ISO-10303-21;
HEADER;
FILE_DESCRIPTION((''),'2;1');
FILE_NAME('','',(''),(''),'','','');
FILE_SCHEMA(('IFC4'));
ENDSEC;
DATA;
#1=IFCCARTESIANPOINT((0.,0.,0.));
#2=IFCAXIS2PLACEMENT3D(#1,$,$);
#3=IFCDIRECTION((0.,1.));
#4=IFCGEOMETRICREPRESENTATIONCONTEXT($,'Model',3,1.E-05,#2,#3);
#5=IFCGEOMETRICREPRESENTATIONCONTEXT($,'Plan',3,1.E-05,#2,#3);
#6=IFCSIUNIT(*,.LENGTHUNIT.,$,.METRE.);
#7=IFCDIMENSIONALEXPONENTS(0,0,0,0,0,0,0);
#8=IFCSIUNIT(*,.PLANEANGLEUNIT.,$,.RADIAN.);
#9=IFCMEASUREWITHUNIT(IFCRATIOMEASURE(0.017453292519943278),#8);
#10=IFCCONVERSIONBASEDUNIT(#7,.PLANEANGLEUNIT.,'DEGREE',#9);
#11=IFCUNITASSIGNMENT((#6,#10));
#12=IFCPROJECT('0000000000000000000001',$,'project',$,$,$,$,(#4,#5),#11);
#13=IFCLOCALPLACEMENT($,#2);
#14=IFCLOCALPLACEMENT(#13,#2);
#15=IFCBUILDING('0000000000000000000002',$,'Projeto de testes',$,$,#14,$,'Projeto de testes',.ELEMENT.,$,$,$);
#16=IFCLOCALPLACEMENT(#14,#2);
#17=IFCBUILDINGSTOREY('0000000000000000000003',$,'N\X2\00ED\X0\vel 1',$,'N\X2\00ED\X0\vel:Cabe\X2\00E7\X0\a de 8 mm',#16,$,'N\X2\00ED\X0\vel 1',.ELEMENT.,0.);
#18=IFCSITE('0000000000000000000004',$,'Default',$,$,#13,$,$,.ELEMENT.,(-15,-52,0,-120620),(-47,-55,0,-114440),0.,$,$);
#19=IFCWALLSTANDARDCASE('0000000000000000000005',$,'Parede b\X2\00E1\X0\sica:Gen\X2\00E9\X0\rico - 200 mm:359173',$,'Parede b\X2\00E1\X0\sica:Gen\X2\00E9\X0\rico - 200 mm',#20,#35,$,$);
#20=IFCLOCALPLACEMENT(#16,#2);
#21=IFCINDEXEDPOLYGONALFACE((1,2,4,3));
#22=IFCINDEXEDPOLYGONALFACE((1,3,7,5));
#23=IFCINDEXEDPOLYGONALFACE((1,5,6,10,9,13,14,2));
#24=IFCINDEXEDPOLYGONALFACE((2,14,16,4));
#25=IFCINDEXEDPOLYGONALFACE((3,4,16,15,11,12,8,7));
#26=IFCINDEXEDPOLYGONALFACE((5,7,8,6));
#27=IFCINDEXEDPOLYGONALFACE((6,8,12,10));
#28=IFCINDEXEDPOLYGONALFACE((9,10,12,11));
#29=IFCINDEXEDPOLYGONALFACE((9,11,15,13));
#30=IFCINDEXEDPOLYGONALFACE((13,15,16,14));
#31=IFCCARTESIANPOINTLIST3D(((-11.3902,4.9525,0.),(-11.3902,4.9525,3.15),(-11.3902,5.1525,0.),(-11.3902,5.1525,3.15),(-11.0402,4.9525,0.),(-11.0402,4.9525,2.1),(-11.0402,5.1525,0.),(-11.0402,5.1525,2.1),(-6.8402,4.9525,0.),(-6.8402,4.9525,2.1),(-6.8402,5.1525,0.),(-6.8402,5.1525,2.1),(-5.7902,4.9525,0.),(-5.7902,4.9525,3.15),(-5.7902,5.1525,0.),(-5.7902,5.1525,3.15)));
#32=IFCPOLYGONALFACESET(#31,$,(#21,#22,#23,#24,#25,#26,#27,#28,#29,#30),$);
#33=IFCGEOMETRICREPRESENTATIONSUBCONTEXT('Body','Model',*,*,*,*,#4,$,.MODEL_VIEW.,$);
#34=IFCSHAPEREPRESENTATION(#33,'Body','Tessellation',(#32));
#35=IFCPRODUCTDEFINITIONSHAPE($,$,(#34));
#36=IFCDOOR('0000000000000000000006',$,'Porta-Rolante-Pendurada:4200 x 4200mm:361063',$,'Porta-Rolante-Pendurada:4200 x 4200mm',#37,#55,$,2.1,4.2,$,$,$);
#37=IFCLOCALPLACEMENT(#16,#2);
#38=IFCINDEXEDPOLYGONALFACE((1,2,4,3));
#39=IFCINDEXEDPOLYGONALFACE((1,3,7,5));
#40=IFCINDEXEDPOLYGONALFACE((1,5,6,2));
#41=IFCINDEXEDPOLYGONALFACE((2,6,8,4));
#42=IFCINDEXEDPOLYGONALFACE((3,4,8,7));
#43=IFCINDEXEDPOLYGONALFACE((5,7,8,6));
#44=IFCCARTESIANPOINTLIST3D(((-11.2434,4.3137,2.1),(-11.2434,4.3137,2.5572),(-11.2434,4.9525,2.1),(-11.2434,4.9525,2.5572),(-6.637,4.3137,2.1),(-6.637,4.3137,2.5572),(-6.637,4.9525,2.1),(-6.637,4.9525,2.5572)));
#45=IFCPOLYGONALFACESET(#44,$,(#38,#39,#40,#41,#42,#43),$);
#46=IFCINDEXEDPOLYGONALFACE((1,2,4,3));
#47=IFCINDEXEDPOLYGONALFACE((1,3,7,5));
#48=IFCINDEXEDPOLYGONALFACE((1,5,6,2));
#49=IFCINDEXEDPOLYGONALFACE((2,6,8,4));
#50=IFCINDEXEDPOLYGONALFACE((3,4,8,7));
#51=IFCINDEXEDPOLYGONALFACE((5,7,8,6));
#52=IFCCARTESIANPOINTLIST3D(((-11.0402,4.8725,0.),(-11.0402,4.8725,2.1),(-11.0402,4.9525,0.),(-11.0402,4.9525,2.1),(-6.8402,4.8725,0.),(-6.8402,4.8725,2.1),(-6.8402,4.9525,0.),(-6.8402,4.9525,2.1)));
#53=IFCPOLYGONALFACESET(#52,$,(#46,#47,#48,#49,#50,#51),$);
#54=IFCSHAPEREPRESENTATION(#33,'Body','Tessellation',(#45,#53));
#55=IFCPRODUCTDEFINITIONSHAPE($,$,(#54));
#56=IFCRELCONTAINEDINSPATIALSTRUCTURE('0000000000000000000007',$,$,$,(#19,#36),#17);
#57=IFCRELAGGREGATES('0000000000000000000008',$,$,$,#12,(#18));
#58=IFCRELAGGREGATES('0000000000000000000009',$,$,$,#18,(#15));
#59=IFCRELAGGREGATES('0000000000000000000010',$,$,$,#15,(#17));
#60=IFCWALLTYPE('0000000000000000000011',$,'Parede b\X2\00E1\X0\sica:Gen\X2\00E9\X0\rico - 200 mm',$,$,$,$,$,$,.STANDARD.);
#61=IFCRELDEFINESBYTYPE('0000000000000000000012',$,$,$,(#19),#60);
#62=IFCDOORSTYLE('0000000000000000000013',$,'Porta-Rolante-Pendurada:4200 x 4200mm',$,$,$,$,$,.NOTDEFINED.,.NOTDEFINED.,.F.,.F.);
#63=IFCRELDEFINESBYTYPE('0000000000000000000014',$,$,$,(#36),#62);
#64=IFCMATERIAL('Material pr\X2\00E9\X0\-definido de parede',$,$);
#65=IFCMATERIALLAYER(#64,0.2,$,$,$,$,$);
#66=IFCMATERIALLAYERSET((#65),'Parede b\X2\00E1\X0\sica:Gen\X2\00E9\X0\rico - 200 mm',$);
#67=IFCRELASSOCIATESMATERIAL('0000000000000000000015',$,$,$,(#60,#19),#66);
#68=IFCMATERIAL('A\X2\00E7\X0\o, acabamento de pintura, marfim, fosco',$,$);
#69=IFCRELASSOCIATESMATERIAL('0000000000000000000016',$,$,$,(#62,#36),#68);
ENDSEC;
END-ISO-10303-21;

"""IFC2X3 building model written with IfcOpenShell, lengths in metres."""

from ifc_helpers import new_model, entity, si_unit, converted_unit, direction, frame, frame_2d, origin, origin_2d_with_axis, place, context, subcontext, project, spatial, rectangle, extrude, source, transform, mapped, material, layer, layer_set, layer_usage, type_object, type_shapes, element, fill, save


model = new_model("IFC2X3")

# Units and contexts
model_context = context("Model", 3, precision=1e-05, world=origin(), true_north=direction((0.0, 1.0)))
plan_context = context("Plan", 3, precision=1e-05, world=origin(), true_north=direction((0.0, 1.0)))
body_context = subcontext(model_context, "Body", "Model", "MODEL_VIEW")
ifc_project = project(units=[si_unit("LENGTHUNIT", "METRE"), converted_unit("PLANEANGLEUNIT", "DEGREE", entity("IfcRatioMeasure", 0.017453292519943278), si_unit("PLANEANGLEUNIT", "RADIAN"), dimensions=[0, 0, 0, 0, 0, 0, 0])], contexts=[model_context, plan_context])

# Site, building, storey
site_placement = place(None, origin())
site = spatial("IfcSite", under=ifc_project, at=site_placement, Name="Default", CompositionType="ELEMENT", RefLatitude=(-15, -52, 0, -120620), RefLongitude=(-47, -55, 0, -114440), RefElevation=0.0)
building_placement = place(site_placement, origin())
building = spatial("IfcBuilding", under=site, at=building_placement, Name="Projeto de testes", LongName="Projeto de testes", CompositionType="ELEMENT")
storey_placement = place(building_placement, origin())
storey = spatial("IfcBuildingStorey", under=building, at=storey_placement, Name="Nível 1", ObjectType="Nível:Cabeça de 8 mm", LongName="Nível 1", CompositionType="ELEMENT", Elevation=0.0)

# Shared definitions
ifc_material_1 = material(Name="Material pré-definido de parede")
ifc_layer_1 = layer(ifc_material_1, 0.2)
ifc_layer_set_1 = layer_set([ifc_layer_1], Name="Parede básica:Genérico - 200 mm")
wall_type = type_object("IfcWallType", Name="Parede básica:Genérico - 200 mm", PredefinedType="STANDARD", material=ifc_layer_set_1)

# Shared definitions
ifc_layer_usage_1 = layer_usage(ifc_layer_set_1, "AXIS2", "NEGATIVE", 0.1)

# Wall, opening, door
wall_1_placement = place(storey_placement, frame((-5.7902, 5.0525, 0.0), z_axis=(0.0, 0.0, 1.0), x_axis=(-1.0, 0.0, 0.0)))
wall_1 = element("IfcWallStandardCase", 1, at=wall_1_placement, inside=storey, type_object=wall_type, material=ifc_layer_usage_1, Name="Parede básica:Genérico - 200 mm:359173", ObjectType="Parede básica:Genérico - 200 mm", context=body_context, shape_type="SweptSolid", body=[
    extrude(rectangle(XDim=5.6, YDim=0.2, at=frame_2d((2.8, 0.0), x_axis=(1.0, 0.0))), origin(), (0.0, 0.0, 1.0), 3.15),
])
opening_1_placement = place(wall_1_placement, frame((1.05, -0.1, 0.0)))
opening_1 = element("IfcOpeningElement", 2, at=opening_1_placement, cuts=wall_1, ObjectType="Opening", context=body_context, shape_type="SweptSolid", body=[
    extrude(rectangle(XDim=2.1, YDim=4.2, at=frame_2d((1.05, 2.1), x_axis=(1.0, 0.0))), frame((0.0, 0.0, 0.0), z_axis=(0.0, 1.0, 0.0), x_axis=(0.0, 0.0, 1.0)), (0.0, 0.0, 1.0), 0.2),
])
ifc_material_2 = material(Name="Aço, acabamento de pintura, marfim, fosco")
door_style_1 = type_object("IfcDoorStyle", Name="Porta-Rolante-Pendurada:4200 x 4200mm", ConstructionType="NOTDEFINED", OperationType="NOTDEFINED", ParameterTakesPrecedence=False, Sizeable=False, material=ifc_material_2)
shared_shape_1 = source(origin(), body_context, "Body", "SweptSolid", [
    extrude(rectangle(XDim=0.6388, YDim=4.6064, at=frame_2d((0.0, 0.0), x_axis=(1.0, 0.0))), frame((2.1, -0.3194, 2.1), z_axis=(0.0, 0.0, 1.0), x_axis=(0.0, 1.0, 0.0)), (0.0, 0.0, 1.0), 0.4572),
    extrude(rectangle(XDim=4.2, YDim=0.08, at=origin_2d_with_axis()), frame((2.1, -0.04, 0.0), z_axis=(0.0, 0.0, 1.0), x_axis=(-1.0, 0.0, 0.0)), (0.0, 0.0, 1.0), 2.1),
])
type_shapes(door_style_1, [shared_shape_1])
door_1_placement = place(opening_1_placement, frame((4.2, 0.2, 0.0), z_axis=(0.0, 0.0, 1.0), x_axis=(-1.0, 0.0, 0.0)))
door_1 = element("IfcDoor", 3, at=door_1_placement, inside=storey, type_object=door_style_1, material=ifc_material_2, Name="Porta-Rolante-Pendurada:4200 x 4200mm:361063", ObjectType="Porta-Rolante-Pendurada:4200 x 4200mm", OverallHeight=2.1, OverallWidth=4.2, context=body_context, shape_type="MappedRepresentation", body=[
    mapped(shared_shape_1, transform((0.0, 0.0, 0.0), scale=1.0)),
])
fill(opening_1, door_1)

save(model, "model.ifc")
